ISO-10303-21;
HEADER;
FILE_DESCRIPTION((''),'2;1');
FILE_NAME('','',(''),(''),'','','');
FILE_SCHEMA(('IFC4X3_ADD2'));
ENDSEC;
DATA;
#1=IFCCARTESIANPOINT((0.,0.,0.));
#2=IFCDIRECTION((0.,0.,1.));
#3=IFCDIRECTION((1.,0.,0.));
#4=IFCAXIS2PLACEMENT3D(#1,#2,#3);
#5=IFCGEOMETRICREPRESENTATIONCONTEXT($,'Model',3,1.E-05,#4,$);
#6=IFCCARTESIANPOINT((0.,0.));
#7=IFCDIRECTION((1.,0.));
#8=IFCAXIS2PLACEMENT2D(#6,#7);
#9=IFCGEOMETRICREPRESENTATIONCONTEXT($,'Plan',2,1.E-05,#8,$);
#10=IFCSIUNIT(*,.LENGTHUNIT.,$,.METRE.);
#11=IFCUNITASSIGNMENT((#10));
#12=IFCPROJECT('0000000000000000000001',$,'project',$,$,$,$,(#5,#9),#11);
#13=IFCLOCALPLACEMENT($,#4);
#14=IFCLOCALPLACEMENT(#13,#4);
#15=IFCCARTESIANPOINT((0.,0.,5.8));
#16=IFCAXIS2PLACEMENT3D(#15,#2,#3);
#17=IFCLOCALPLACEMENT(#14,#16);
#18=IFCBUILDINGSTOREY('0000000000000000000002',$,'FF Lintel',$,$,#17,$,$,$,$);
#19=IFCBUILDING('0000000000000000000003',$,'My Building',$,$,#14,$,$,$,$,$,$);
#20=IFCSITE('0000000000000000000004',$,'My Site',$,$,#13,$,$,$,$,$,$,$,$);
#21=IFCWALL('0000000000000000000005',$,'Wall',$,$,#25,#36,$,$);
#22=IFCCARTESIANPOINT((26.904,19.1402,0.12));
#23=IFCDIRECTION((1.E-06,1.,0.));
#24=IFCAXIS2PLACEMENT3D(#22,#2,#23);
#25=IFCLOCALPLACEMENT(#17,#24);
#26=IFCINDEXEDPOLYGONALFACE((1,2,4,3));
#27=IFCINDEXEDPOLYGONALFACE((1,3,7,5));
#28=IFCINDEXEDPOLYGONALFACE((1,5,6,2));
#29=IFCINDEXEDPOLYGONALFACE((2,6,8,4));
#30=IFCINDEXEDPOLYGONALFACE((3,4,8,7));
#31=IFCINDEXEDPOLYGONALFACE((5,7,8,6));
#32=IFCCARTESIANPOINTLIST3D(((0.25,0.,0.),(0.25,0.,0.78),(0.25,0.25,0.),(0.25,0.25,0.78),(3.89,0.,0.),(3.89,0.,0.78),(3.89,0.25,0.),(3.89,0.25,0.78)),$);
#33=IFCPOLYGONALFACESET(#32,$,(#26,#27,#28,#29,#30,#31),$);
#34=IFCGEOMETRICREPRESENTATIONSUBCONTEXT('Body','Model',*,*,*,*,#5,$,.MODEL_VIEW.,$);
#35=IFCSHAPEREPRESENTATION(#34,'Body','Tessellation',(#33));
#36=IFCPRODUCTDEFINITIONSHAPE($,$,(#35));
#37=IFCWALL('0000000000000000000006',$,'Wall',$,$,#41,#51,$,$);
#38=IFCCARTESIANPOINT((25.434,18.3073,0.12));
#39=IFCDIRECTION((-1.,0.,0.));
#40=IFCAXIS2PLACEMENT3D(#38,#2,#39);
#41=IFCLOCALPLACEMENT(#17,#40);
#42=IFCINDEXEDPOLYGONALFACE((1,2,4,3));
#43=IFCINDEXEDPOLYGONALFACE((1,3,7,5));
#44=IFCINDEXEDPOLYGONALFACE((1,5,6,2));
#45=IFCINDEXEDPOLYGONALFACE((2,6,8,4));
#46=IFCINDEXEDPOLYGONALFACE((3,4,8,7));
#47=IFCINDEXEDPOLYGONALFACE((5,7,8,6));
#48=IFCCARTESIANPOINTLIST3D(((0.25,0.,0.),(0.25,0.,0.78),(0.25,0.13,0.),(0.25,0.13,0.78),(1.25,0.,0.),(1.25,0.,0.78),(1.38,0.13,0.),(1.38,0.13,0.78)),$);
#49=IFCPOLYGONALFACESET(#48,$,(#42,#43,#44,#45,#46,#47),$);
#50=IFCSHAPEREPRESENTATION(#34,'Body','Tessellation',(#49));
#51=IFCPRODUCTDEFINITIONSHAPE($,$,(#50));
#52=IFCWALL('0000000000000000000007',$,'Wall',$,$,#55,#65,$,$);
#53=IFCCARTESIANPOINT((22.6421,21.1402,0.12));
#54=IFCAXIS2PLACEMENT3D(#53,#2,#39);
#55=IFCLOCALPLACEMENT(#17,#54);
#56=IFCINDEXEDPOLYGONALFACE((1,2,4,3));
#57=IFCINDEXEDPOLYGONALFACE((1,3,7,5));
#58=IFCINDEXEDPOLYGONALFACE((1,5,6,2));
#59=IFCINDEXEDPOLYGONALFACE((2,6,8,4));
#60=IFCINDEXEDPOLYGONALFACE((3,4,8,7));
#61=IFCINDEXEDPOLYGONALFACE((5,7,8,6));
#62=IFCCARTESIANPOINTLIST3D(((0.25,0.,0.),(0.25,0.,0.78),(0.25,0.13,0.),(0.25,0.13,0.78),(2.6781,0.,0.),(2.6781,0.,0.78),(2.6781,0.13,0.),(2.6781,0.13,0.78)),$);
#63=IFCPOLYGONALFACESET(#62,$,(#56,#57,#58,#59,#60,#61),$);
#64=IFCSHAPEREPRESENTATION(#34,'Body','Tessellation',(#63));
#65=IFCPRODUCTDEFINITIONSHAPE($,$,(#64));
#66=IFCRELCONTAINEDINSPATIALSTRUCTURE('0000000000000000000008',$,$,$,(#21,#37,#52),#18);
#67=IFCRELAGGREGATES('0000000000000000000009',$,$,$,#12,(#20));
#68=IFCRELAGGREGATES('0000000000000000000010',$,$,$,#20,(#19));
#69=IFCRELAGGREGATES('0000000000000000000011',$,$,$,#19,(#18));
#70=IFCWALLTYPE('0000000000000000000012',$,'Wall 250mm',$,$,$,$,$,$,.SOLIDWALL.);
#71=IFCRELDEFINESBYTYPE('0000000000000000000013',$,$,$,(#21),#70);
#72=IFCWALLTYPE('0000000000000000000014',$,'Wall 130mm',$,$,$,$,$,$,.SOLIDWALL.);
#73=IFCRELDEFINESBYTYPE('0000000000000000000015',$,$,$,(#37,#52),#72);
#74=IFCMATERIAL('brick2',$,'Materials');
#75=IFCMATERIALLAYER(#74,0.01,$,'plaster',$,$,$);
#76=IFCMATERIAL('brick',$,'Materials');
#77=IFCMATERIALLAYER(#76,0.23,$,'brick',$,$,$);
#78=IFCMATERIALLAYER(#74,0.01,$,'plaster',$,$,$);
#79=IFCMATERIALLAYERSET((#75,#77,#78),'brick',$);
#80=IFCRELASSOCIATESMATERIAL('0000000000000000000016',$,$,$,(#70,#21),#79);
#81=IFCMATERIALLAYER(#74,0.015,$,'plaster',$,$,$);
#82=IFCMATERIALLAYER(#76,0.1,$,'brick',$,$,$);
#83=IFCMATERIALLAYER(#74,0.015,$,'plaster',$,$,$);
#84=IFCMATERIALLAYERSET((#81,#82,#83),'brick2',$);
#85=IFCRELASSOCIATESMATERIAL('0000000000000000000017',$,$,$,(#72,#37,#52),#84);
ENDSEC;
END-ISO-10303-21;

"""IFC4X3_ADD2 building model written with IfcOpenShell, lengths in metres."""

from ifc_helpers import new_model, si_unit, frame, origin_with_axes, origin_2d_with_axis, place, context, subcontext, project, spatial, line, indexed_curve, outline, extrude, material, layer, layer_set, layer_usage, type_object, element, save


model = new_model("IFC4X3_ADD2")

# Units and contexts
model_context = context("Model", 3, precision=1e-05, world=origin_with_axes())
plan_context = context("Plan", 2, precision=1e-05, world=origin_2d_with_axis())
body_context = subcontext(model_context, "Body", "Model", "MODEL_VIEW")
ifc_project = project(units=[si_unit("LENGTHUNIT", "METRE")], contexts=[model_context, plan_context])

# Site, building, storey
site_placement = place(None, origin_with_axes())
site = spatial("IfcSite", under=ifc_project, at=site_placement, Name="My Site")
building_placement = place(site_placement, origin_with_axes())
building = spatial("IfcBuilding", under=site, at=building_placement, Name="My Building")
storey_placement = place(building_placement, frame((0.0, 0.0, 5.8), z_axis=(0.0, 0.0, 1.0), x_axis=(1.0, 0.0, 0.0)))
storey = spatial("IfcBuildingStorey", under=building, at=storey_placement, Name="FF Lintel")

# Walls
ifc_material_1 = material(Name="brick2", Category="Materials")
ifc_layer_1 = layer(ifc_material_1, 0.01, Name="plaster")
ifc_material_2 = material(Name="brick", Category="Materials")
ifc_layer_2 = layer(ifc_material_2, 0.23, Name="brick")
ifc_layer_3 = layer(ifc_material_1, 0.01, Name="plaster")
ifc_layer_set_1 = layer_set([ifc_layer_1, ifc_layer_2, ifc_layer_3], Name="brick")
wall_type_1 = type_object("IfcWallType", Name="Wall 250mm", PredefinedType="SOLIDWALL", material=ifc_layer_set_1)
ifc_layer_usage_1 = layer_usage(ifc_layer_set_1, "AXIS2", "POSITIVE", 0.0)
wall_1_placement = place(storey_placement, frame((26.904, 19.1402, 0.12), z_axis=(0.0, 0.0, 1.0), x_axis=(0.000001, 1.0, 0.0)))
element("IfcWall", 1, at=wall_1_placement, inside=storey, type_object=wall_type_1, material=ifc_layer_usage_1, Name="Wall", context=body_context, shape_type="SweptSolid", body=[
    extrude(outline(indexed_curve([(0.25, 0.0), (0.25, 0.25), (3.89, 0.25), (3.89, 0.0)], segments=[line(1, 2, 3, 4, 1)])), origin_with_axes(), (0.0, 0.0, 1.0), 0.78),
])
ifc_layer_4 = layer(ifc_material_1, 0.015, Name="plaster")
ifc_layer_5 = layer(ifc_material_2, 0.1, Name="brick")
ifc_layer_6 = layer(ifc_material_1, 0.015, Name="plaster")
ifc_layer_set_2 = layer_set([ifc_layer_4, ifc_layer_5, ifc_layer_6], Name="brick2")
ifc_layer_usage_2 = layer_usage(ifc_layer_set_2, "AXIS2", "POSITIVE", 0.0)
wall_type_2 = type_object("IfcWallType", Name="Wall 130mm", PredefinedType="SOLIDWALL", material=ifc_layer_set_2)
wall_2_placement = place(storey_placement, frame((25.434, 18.3073, 0.12), z_axis=(0.0, 0.0, 1.0), x_axis=(-1.0, 0.0, 0.0)))
element("IfcWall", 2, at=wall_2_placement, inside=storey, type_object=wall_type_2, material=ifc_layer_usage_2, Name="Wall", context=body_context, shape_type="SweptSolid", body=[
    extrude(outline(indexed_curve([(0.25, 0.0), (0.25, 0.13), (1.38, 0.13), (1.25, 0.0)], segments=[line(1, 2, 3, 4, 1)])), origin_with_axes(), (0.0, 0.0, 1.0), 0.78),
])
ifc_layer_usage_3 = layer_usage(ifc_layer_set_2, "AXIS2", "POSITIVE", 0.0)
wall_3_placement = place(storey_placement, frame((22.6421, 21.1402, 0.12), z_axis=(0.0, 0.0, 1.0), x_axis=(-1.0, 0.0, 0.0)))
element("IfcWall", 3, at=wall_3_placement, inside=storey, type_object=wall_type_2, material=ifc_layer_usage_3, Name="Wall", context=body_context, shape_type="SweptSolid", body=[
    extrude(outline(indexed_curve([(0.25, 0.0), (0.25, 0.13), (2.6781, 0.13), (2.6781, 0.0)], segments=[line(1, 2, 3, 4, 1)])), origin_with_axes(), (0.0, 0.0, 1.0), 0.78),
])

save(model, "model.ifc")
